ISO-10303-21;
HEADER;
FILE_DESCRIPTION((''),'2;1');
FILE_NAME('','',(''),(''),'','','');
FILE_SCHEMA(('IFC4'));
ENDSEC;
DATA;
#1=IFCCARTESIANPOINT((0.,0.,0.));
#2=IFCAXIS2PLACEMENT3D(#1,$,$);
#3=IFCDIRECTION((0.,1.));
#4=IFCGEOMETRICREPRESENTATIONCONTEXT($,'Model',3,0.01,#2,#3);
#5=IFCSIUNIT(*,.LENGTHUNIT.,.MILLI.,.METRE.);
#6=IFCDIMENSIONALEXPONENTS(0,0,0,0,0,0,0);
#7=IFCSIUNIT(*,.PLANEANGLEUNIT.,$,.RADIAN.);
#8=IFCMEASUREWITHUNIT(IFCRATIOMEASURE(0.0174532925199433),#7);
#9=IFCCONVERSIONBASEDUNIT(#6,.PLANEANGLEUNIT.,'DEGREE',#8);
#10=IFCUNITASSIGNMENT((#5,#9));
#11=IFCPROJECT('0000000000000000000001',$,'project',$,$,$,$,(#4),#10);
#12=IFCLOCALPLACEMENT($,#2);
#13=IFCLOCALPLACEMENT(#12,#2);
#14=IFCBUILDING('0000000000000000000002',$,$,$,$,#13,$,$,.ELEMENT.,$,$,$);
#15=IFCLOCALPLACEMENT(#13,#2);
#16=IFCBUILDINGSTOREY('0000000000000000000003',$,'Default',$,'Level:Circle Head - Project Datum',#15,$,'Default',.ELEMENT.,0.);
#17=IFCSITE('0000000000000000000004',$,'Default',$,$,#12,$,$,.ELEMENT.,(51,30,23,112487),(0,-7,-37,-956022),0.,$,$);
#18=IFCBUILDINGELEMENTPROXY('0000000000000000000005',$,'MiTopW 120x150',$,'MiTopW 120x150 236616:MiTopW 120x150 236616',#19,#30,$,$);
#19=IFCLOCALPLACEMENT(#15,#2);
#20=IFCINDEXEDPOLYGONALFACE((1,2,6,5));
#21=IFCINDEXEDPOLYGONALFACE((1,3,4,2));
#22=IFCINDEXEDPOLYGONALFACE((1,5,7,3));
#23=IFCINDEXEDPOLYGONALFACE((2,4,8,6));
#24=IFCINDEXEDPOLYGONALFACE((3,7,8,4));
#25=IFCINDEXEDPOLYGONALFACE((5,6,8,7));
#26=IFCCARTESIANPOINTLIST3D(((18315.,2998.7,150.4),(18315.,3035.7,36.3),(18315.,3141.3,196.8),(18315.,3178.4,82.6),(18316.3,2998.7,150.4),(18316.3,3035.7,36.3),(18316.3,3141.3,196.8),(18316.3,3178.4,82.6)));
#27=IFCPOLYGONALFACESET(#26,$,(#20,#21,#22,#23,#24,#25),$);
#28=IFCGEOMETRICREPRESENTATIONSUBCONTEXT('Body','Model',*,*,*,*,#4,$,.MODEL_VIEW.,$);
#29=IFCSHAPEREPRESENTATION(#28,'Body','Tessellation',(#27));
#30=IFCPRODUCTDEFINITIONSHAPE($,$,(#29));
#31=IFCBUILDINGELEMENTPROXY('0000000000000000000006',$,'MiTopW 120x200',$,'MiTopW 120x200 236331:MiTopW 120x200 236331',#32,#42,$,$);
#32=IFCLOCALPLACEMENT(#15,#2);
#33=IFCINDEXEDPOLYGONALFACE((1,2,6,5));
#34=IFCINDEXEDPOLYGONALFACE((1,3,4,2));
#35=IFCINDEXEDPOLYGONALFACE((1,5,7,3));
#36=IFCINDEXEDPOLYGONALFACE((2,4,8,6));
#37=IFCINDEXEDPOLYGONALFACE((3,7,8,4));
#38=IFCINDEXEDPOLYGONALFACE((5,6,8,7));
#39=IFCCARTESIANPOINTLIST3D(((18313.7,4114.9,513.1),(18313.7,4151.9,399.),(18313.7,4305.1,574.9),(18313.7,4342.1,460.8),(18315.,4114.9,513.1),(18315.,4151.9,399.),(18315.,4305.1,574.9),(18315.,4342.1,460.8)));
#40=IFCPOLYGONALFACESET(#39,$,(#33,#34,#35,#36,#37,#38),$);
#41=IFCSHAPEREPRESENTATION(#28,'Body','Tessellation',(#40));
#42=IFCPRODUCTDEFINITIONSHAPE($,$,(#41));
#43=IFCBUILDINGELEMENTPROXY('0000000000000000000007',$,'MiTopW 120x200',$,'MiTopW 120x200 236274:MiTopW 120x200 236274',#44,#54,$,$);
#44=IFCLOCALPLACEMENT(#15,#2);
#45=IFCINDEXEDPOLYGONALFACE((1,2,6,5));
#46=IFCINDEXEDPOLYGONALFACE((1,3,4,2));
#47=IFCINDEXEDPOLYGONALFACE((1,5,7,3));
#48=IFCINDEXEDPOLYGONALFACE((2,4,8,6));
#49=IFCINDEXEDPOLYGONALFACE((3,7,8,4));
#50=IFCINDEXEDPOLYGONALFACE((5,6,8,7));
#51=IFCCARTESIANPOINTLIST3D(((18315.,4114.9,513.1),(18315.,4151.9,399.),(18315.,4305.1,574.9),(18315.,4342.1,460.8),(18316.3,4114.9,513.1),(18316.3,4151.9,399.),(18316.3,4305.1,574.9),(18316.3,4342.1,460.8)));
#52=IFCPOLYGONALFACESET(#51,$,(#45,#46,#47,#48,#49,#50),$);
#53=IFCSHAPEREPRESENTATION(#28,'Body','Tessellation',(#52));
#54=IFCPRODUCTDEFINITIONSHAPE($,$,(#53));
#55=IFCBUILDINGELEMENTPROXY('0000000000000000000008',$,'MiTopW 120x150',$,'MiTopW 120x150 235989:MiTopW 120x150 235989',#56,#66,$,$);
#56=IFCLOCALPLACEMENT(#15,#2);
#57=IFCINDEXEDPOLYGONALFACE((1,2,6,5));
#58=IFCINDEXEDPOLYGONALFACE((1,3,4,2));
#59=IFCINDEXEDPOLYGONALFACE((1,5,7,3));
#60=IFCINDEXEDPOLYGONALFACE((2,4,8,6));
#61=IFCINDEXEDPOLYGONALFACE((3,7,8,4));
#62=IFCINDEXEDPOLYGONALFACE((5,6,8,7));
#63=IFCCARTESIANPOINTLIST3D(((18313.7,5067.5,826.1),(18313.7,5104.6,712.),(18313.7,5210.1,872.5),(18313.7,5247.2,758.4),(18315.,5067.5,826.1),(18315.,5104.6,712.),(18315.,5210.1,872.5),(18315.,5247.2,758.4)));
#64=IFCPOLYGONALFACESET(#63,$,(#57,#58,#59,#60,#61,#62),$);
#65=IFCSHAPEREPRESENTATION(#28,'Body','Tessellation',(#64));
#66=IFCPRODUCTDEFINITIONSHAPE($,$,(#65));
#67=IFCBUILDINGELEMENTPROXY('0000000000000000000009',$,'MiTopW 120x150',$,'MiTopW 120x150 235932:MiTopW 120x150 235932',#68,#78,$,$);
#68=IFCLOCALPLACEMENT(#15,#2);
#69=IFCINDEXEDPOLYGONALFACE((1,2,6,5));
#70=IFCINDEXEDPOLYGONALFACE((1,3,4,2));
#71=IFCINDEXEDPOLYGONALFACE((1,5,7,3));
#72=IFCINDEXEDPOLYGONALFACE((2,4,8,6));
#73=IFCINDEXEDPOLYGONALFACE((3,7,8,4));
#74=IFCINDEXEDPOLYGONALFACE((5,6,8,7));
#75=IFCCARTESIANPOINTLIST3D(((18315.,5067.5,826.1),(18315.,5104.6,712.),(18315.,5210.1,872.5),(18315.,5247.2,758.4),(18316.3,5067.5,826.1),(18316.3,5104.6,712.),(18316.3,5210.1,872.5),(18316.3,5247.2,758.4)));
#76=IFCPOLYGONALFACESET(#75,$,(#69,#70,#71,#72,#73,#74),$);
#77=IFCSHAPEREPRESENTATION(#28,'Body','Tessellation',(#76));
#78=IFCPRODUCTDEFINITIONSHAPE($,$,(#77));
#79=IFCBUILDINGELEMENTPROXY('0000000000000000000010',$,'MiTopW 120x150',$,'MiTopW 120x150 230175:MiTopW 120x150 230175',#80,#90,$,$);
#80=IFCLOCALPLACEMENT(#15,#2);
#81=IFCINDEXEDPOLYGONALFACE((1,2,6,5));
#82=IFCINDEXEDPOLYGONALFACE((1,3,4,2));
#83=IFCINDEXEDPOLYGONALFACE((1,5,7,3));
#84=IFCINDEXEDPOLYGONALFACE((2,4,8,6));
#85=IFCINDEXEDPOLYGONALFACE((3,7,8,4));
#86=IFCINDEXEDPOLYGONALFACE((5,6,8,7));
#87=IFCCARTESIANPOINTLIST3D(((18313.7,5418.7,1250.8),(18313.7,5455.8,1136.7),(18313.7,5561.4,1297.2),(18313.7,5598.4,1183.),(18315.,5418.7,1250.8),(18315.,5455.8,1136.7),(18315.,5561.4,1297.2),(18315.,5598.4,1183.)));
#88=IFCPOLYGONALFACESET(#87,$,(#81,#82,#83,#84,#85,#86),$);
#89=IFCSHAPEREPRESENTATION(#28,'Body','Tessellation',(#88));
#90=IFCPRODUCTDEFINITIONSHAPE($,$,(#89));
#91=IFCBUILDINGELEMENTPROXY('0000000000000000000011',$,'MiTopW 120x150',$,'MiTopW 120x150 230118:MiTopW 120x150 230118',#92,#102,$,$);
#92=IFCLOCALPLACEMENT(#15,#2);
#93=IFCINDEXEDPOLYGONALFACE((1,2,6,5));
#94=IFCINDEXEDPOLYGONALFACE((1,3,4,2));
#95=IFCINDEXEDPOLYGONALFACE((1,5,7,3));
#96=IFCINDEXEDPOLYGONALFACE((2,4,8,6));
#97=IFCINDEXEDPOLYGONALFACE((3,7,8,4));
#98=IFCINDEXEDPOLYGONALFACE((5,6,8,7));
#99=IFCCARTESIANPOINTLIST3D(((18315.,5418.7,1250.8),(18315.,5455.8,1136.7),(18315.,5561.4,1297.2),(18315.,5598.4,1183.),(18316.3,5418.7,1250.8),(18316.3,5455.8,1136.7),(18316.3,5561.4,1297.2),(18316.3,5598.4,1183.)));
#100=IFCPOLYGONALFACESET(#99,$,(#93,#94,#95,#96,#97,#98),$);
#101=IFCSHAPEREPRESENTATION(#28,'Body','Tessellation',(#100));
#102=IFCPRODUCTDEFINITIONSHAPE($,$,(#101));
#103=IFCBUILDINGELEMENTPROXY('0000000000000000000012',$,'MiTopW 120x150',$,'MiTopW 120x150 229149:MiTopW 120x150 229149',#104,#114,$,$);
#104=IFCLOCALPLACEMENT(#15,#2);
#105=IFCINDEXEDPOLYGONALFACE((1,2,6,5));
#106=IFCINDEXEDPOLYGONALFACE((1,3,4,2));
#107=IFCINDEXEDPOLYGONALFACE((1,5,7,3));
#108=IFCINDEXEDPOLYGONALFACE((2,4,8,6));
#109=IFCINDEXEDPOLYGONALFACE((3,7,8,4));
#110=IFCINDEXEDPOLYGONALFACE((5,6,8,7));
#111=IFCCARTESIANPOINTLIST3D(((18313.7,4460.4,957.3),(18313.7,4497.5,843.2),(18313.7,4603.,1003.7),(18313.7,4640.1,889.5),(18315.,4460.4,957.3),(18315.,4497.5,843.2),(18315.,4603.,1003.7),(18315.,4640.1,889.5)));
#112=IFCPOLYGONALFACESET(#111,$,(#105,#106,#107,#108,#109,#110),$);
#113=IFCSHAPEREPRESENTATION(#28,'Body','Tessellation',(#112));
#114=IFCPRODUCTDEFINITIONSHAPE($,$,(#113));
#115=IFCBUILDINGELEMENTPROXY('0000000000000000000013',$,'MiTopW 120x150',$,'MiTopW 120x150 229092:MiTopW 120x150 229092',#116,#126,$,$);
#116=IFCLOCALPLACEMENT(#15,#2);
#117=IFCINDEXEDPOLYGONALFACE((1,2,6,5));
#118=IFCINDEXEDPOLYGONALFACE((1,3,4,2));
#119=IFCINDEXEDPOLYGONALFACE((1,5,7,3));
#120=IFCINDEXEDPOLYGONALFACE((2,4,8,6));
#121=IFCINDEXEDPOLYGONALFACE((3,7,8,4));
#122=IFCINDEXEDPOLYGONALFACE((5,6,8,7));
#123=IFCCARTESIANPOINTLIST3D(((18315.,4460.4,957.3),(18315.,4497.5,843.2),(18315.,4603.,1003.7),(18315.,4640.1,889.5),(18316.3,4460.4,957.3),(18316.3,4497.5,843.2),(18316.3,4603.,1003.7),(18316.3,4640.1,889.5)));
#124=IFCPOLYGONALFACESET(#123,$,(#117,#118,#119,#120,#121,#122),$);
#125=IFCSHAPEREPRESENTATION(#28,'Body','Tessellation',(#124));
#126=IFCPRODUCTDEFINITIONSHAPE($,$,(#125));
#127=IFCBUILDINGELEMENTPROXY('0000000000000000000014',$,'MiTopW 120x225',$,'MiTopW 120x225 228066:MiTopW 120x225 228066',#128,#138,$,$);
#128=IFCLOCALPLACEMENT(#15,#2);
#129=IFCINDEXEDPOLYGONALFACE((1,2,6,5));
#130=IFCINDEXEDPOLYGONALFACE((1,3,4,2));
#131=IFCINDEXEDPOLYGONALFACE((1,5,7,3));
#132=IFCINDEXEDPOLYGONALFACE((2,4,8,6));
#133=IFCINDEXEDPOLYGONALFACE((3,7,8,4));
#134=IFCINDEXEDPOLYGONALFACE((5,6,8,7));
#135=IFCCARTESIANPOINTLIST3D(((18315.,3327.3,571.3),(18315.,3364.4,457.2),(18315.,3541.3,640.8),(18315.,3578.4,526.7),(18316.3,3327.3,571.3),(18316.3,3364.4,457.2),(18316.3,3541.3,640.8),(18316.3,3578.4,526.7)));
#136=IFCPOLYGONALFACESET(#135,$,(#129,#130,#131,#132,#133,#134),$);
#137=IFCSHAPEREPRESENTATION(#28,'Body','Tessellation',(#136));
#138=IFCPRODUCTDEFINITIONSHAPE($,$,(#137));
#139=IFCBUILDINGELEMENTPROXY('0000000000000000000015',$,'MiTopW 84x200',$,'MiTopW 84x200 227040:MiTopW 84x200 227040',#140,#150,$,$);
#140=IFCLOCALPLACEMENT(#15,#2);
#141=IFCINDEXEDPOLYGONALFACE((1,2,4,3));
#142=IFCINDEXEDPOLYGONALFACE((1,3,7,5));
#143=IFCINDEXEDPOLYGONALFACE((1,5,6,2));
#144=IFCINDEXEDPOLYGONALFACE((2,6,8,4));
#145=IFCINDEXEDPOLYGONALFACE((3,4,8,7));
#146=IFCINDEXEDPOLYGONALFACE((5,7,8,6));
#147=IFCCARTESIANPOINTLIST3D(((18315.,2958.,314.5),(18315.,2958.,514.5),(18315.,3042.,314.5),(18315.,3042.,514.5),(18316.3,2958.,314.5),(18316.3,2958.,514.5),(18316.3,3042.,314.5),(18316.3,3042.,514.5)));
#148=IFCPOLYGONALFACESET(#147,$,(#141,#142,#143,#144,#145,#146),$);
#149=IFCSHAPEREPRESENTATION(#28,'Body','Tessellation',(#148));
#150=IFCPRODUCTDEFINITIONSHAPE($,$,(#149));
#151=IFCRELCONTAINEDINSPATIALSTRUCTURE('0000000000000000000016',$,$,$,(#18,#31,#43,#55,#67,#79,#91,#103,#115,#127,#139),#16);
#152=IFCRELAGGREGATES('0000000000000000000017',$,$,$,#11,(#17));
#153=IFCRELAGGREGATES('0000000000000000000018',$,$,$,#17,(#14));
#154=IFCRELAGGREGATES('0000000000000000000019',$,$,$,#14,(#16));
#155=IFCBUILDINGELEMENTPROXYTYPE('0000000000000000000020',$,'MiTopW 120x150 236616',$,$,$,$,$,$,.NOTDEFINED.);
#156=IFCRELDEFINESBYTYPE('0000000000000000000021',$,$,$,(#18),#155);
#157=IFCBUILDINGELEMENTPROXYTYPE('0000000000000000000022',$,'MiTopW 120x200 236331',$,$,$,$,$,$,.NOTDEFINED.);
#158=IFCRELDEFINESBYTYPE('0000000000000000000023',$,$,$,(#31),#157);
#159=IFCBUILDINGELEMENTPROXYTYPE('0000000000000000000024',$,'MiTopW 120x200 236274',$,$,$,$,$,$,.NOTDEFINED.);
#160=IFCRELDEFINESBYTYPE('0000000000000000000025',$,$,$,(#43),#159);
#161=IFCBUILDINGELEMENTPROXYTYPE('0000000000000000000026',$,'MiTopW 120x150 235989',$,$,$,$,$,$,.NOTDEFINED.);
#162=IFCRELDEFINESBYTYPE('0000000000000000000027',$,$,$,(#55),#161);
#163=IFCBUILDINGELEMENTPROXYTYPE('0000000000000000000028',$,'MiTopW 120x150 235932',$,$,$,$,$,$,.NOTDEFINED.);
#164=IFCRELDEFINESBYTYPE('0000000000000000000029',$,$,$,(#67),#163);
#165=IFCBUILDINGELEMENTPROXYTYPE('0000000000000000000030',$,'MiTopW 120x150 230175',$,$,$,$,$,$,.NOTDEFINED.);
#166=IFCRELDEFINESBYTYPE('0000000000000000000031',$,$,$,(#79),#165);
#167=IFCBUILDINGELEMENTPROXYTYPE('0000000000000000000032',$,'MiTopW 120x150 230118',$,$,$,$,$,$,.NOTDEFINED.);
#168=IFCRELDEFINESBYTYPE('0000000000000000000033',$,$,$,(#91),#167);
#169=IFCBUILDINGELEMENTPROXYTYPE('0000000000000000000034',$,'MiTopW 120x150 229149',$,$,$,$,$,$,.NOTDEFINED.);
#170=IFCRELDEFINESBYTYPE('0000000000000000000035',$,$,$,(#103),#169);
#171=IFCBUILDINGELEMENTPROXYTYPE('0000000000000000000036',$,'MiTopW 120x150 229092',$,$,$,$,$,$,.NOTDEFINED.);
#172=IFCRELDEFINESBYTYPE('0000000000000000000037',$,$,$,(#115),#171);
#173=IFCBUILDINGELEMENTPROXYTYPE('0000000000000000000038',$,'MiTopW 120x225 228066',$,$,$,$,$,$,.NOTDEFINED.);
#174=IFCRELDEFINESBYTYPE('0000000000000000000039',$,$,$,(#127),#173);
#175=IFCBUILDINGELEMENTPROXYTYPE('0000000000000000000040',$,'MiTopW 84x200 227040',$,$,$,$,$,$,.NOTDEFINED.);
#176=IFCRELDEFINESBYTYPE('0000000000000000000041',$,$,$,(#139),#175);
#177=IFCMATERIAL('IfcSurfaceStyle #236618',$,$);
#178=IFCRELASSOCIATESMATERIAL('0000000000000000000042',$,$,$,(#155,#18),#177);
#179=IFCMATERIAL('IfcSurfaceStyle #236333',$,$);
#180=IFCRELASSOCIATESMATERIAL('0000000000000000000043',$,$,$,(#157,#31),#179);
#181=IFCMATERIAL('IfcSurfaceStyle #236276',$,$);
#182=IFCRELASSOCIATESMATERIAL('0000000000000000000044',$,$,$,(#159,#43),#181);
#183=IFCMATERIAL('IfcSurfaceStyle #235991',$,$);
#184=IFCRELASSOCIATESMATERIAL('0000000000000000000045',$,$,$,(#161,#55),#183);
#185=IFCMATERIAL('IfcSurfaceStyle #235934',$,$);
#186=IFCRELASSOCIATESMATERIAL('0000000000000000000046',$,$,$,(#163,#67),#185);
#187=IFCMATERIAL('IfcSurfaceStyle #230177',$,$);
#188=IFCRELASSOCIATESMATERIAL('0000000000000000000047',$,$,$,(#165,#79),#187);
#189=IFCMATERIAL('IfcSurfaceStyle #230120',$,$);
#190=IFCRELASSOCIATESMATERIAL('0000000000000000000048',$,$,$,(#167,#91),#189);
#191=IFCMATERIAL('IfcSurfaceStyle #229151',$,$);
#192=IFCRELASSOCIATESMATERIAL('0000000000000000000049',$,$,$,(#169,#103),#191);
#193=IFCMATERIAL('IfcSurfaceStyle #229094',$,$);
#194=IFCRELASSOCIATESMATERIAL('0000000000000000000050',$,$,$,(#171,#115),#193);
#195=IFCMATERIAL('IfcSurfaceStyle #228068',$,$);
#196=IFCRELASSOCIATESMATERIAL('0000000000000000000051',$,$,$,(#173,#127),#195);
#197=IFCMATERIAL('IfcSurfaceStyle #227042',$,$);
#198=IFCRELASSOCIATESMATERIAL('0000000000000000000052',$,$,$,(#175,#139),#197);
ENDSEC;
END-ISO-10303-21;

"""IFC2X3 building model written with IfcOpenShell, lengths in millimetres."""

from ifc_helpers import new_model, entity, si_unit, converted_unit, direction, frame, frame_2d, origin, place, context, subcontext, project, spatial, polyline, rectangle, outline, extrude, source, transform, mapped, material, type_object, type_shapes, element, save


model = new_model("IFC2X3")

# Units and contexts
model_context = context("Model", 3, precision=0.01, world=origin(), true_north=direction((0.0, 1.0)))
body_context = subcontext(model_context, "Body", "Model", "MODEL_VIEW")
ifc_project = project(units=[si_unit("LENGTHUNIT", "METRE", prefix="MILLI"), converted_unit("PLANEANGLEUNIT", "DEGREE", entity("IfcRatioMeasure", 0.0174532925199433), si_unit("PLANEANGLEUNIT", "RADIAN"), dimensions=[0, 0, 0, 0, 0, 0, 0])], contexts=[model_context])

# Site, building, storey
site_placement = place(None, origin())
site = spatial("IfcSite", under=ifc_project, at=site_placement, Name="Default", CompositionType="ELEMENT", RefLatitude=(51, 30, 23, 112487), RefLongitude=(0, -7, -37, -956022), RefElevation=0.0)
building_placement = place(site_placement, origin())
building = spatial("IfcBuilding", under=site, at=building_placement, CompositionType="ELEMENT")
storey_placement = place(building_placement, origin())
storey = spatial("IfcBuildingStorey", under=building, at=storey_placement, Name="Default", ObjectType="Level:Circle Head - Project Datum", LongName="Default", CompositionType="ELEMENT", Elevation=0.0)

# Building element proxies
ifc_material_1 = material(Name="IfcSurfaceStyle #236618")
building_element_proxy_type_1 = type_object("IfcBuildingElementProxyType", Name="MiTopW 120x150 236616", PredefinedType="NOTDEFINED", material=ifc_material_1)
shared_shape_1 = source(origin(), body_context, "Body", "SweptSolid", [
    extrude(outline(polyline([(-75.0, -60.0), (75.0, -60.0), (75.0, 60.0), (-75.0, 60.0), (-75.0, -60.0)])), frame((75.0, 60.0, 0.0), z_axis=(0.0, 0.0, 1.0), x_axis=(-1.0, 0.0, 0.0)), (0.0, 0.0, 1.0), 1.3),
])
type_shapes(building_element_proxy_type_1, [shared_shape_1])
proxy_1_placement = place(building_placement, frame((18316.3, 2998.7, 150.4), z_axis=(-1.0, 0.0, 0.0), x_axis=(0.0, 0.951057, 0.309017)))
element("IfcBuildingElementProxy", 1, at=proxy_1_placement, inside=storey, type_object=building_element_proxy_type_1, material=ifc_material_1, Name="MiTopW 120x150", ObjectType="MiTopW 120x150 236616:MiTopW 120x150 236616", context=body_context, shape_type="MappedRepresentation", body=[
    mapped(shared_shape_1, transform((0.0, 0.0, 0.0), scale=1.0)),
])
ifc_material_2 = material(Name="IfcSurfaceStyle #236333")
building_element_proxy_type_2 = type_object("IfcBuildingElementProxyType", Name="MiTopW 120x200 236331", PredefinedType="NOTDEFINED", material=ifc_material_2)
shared_shape_2 = source(origin(), body_context, "Body", "SweptSolid", [
    extrude(outline(polyline([(-100.0, -60.0), (100.0, -60.0), (100.0, 60.0), (-100.0, 60.0), (-100.0, -60.0)])), frame((100.0, 60.0, 0.0), z_axis=(0.0, 0.0, 1.0), x_axis=(-1.0, 0.0, 0.0)), (0.0, 0.0, 1.0), 1.3),
])
type_shapes(building_element_proxy_type_2, [shared_shape_2])
proxy_2_placement = place(building_placement, frame((18315.0, 4114.9, 513.1), z_axis=(-1.0, 0.0, 0.0), x_axis=(0.0, 0.951057, 0.309017)))
element("IfcBuildingElementProxy", 2, at=proxy_2_placement, inside=storey, type_object=building_element_proxy_type_2, material=ifc_material_2, Name="MiTopW 120x200", ObjectType="MiTopW 120x200 236331:MiTopW 120x200 236331", context=body_context, shape_type="MappedRepresentation", body=[
    mapped(shared_shape_2, transform((0.0, 0.0, 0.0), scale=1.0)),
])
ifc_material_3 = material(Name="IfcSurfaceStyle #236276")
building_element_proxy_type_3 = type_object("IfcBuildingElementProxyType", Name="MiTopW 120x200 236274", PredefinedType="NOTDEFINED", material=ifc_material_3)
shared_shape_3 = source(origin(), body_context, "Body", "SweptSolid", [
    extrude(outline(polyline([(-100.0, -60.0), (100.0, -60.0), (100.0, 60.0), (-100.0, 60.0), (-100.0, -60.0)])), frame((100.0, 60.0, 0.0), z_axis=(0.0, 0.0, 1.0), x_axis=(-1.0, 0.0, 0.0)), (0.0, 0.0, 1.0), 1.3),
])
type_shapes(building_element_proxy_type_3, [shared_shape_3])
proxy_3_placement = place(building_placement, frame((18316.3, 4114.9, 513.1), z_axis=(-1.0, 0.0, 0.0), x_axis=(0.0, 0.951057, 0.309017)))
element("IfcBuildingElementProxy", 3, at=proxy_3_placement, inside=storey, type_object=building_element_proxy_type_3, material=ifc_material_3, Name="MiTopW 120x200", ObjectType="MiTopW 120x200 236274:MiTopW 120x200 236274", context=body_context, shape_type="MappedRepresentation", body=[
    mapped(shared_shape_3, transform((0.0, 0.0, 0.0), scale=1.0)),
])
ifc_material_4 = material(Name="IfcSurfaceStyle #235991")
building_element_proxy_type_4 = type_object("IfcBuildingElementProxyType", Name="MiTopW 120x150 235989", PredefinedType="NOTDEFINED", material=ifc_material_4)
shared_shape_4 = source(origin(), body_context, "Body", "SweptSolid", [
    extrude(outline(polyline([(-75.0, -60.0), (75.0, -60.0), (75.0, 60.0), (-75.0, 60.0), (-75.0, -60.0)])), frame((75.0, 60.0, 0.0), z_axis=(0.0, 0.0, 1.0), x_axis=(-1.0, 0.0, 0.0)), (0.0, 0.0, 1.0), 1.3),
])
type_shapes(building_element_proxy_type_4, [shared_shape_4])
proxy_4_placement = place(building_placement, frame((18315.0, 5067.5, 826.1), z_axis=(-1.0, 0.0, 0.0), x_axis=(0.0, 0.951057, 0.309017)))
element("IfcBuildingElementProxy", 4, at=proxy_4_placement, inside=storey, type_object=building_element_proxy_type_4, material=ifc_material_4, Name="MiTopW 120x150", ObjectType="MiTopW 120x150 235989:MiTopW 120x150 235989", context=body_context, shape_type="MappedRepresentation", body=[
    mapped(shared_shape_4, transform((0.0, 0.0, 0.0), scale=1.0)),
])
ifc_material_5 = material(Name="IfcSurfaceStyle #235934")
building_element_proxy_type_5 = type_object("IfcBuildingElementProxyType", Name="MiTopW 120x150 235932", PredefinedType="NOTDEFINED", material=ifc_material_5)
shared_shape_5 = source(origin(), body_context, "Body", "SweptSolid", [
    extrude(outline(polyline([(-75.0, -60.0), (75.0, -60.0), (75.0, 60.0), (-75.0, 60.0), (-75.0, -60.0)])), frame((75.0, 60.0, 0.0), z_axis=(0.0, 0.0, 1.0), x_axis=(-1.0, 0.0, 0.0)), (0.0, 0.0, 1.0), 1.3),
])
type_shapes(building_element_proxy_type_5, [shared_shape_5])
proxy_5_placement = place(building_placement, frame((18316.3, 5067.5, 826.1), z_axis=(-1.0, 0.0, 0.0), x_axis=(0.0, 0.951057, 0.309017)))
element("IfcBuildingElementProxy", 5, at=proxy_5_placement, inside=storey, type_object=building_element_proxy_type_5, material=ifc_material_5, Name="MiTopW 120x150", ObjectType="MiTopW 120x150 235932:MiTopW 120x150 235932", context=body_context, shape_type="MappedRepresentation", body=[
    mapped(shared_shape_5, transform((0.0, 0.0, 0.0), scale=1.0)),
])
ifc_material_6 = material(Name="IfcSurfaceStyle #230177")
building_element_proxy_type_6 = type_object("IfcBuildingElementProxyType", Name="MiTopW 120x150 230175", PredefinedType="NOTDEFINED", material=ifc_material_6)
shared_shape_6 = source(origin(), body_context, "Body", "SweptSolid", [
    extrude(outline(polyline([(-75.0, -60.0), (75.0, -60.0), (75.0, 60.0), (-75.0, 60.0), (-75.0, -60.0)])), frame((75.0, 60.0, 0.0), z_axis=(0.0, 0.0, 1.0), x_axis=(-1.0, 0.0, 0.0)), (0.0, 0.0, 1.0), 1.3),
])
type_shapes(building_element_proxy_type_6, [shared_shape_6])
proxy_6_placement = place(building_placement, frame((18315.0, 5418.7, 1250.8), z_axis=(-1.0, 0.0, 0.0), x_axis=(0.0, 0.951057, 0.309017)))
element("IfcBuildingElementProxy", 6, at=proxy_6_placement, inside=storey, type_object=building_element_proxy_type_6, material=ifc_material_6, Name="MiTopW 120x150", ObjectType="MiTopW 120x150 230175:MiTopW 120x150 230175", context=body_context, shape_type="MappedRepresentation", body=[
    mapped(shared_shape_6, transform((0.0, 0.0, 0.0), scale=1.0)),
])
ifc_material_7 = material(Name="IfcSurfaceStyle #230120")
building_element_proxy_type_7 = type_object("IfcBuildingElementProxyType", Name="MiTopW 120x150 230118", PredefinedType="NOTDEFINED", material=ifc_material_7)
shared_shape_7 = source(origin(), body_context, "Body", "SweptSolid", [
    extrude(outline(polyline([(-75.0, -60.0), (75.0, -60.0), (75.0, 60.0), (-75.0, 60.0), (-75.0, -60.0)])), frame((75.0, 60.0, 0.0), z_axis=(0.0, 0.0, 1.0), x_axis=(-1.0, 0.0, 0.0)), (0.0, 0.0, 1.0), 1.3),
])
type_shapes(building_element_proxy_type_7, [shared_shape_7])
proxy_7_placement = place(building_placement, frame((18316.3, 5418.7, 1250.8), z_axis=(-1.0, 0.0, 0.0), x_axis=(0.0, 0.951057, 0.309017)))
element("IfcBuildingElementProxy", 7, at=proxy_7_placement, inside=storey, type_object=building_element_proxy_type_7, material=ifc_material_7, Name="MiTopW 120x150", ObjectType="MiTopW 120x150 230118:MiTopW 120x150 230118", context=body_context, shape_type="MappedRepresentation", body=[
    mapped(shared_shape_7, transform((0.0, 0.0, 0.0), scale=1.0)),
])
ifc_material_8 = material(Name="IfcSurfaceStyle #229151")
building_element_proxy_type_8 = type_object("IfcBuildingElementProxyType", Name="MiTopW 120x150 229149", PredefinedType="NOTDEFINED", material=ifc_material_8)
shared_shape_8 = source(origin(), body_context, "Body", "SweptSolid", [
    extrude(outline(polyline([(-75.0, -60.0), (75.0, -60.0), (75.0, 60.0), (-75.0, 60.0), (-75.0, -60.0)])), frame((75.0, 60.0, 0.0), z_axis=(0.0, 0.0, 1.0), x_axis=(-1.0, 0.0, 0.0)), (0.0, 0.0, 1.0), 1.3),
])
type_shapes(building_element_proxy_type_8, [shared_shape_8])
proxy_8_placement = place(building_placement, frame((18315.0, 4460.4, 957.3), z_axis=(-1.0, 0.0, 0.0), x_axis=(0.0, 0.951057, 0.309017)))
element("IfcBuildingElementProxy", 8, at=proxy_8_placement, inside=storey, type_object=building_element_proxy_type_8, material=ifc_material_8, Name="MiTopW 120x150", ObjectType="MiTopW 120x150 229149:MiTopW 120x150 229149", context=body_context, shape_type="MappedRepresentation", body=[
    mapped(shared_shape_8, transform((0.0, 0.0, 0.0), scale=1.0)),
])
ifc_material_9 = material(Name="IfcSurfaceStyle #229094")
building_element_proxy_type_9 = type_object("IfcBuildingElementProxyType", Name="MiTopW 120x150 229092", PredefinedType="NOTDEFINED", material=ifc_material_9)
shared_shape_9 = source(origin(), body_context, "Body", "SweptSolid", [
    extrude(outline(polyline([(-75.0, -60.0), (75.0, -60.0), (75.0, 60.0), (-75.0, 60.0), (-75.0, -60.0)])), frame((75.0, 60.0, 0.0), z_axis=(0.0, 0.0, 1.0), x_axis=(-1.0, 0.0, 0.0)), (0.0, 0.0, 1.0), 1.3),
])
type_shapes(building_element_proxy_type_9, [shared_shape_9])
proxy_9_placement = place(building_placement, frame((18316.3, 4460.4, 957.3), z_axis=(-1.0, 0.0, 0.0), x_axis=(0.0, 0.951057, 0.309017)))
element("IfcBuildingElementProxy", 9, at=proxy_9_placement, inside=storey, type_object=building_element_proxy_type_9, material=ifc_material_9, Name="MiTopW 120x150", ObjectType="MiTopW 120x150 229092:MiTopW 120x150 229092", context=body_context, shape_type="MappedRepresentation", body=[
    mapped(shared_shape_9, transform((0.0, 0.0, 0.0), scale=1.0)),
])
ifc_material_10 = material(Name="IfcSurfaceStyle #228068")
building_element_proxy_type_10 = type_object("IfcBuildingElementProxyType", Name="MiTopW 120x225 228066", PredefinedType="NOTDEFINED", material=ifc_material_10)
shared_shape_10 = source(origin(), body_context, "Body", "SweptSolid", [
    extrude(outline(polyline([(-112.5, -60.0), (112.5, -60.0), (112.5, 60.0), (-112.5, 60.0), (-112.5, -60.0)])), frame((112.5, 60.0, 0.0), z_axis=(0.0, 0.0, 1.0), x_axis=(-1.0, 0.0, 0.0)), (0.0, 0.0, 1.0), 1.3),
])
type_shapes(building_element_proxy_type_10, [shared_shape_10])
proxy_10_placement = place(building_placement, frame((18316.3, 3327.3, 571.3), z_axis=(-1.0, 0.0, 0.0), x_axis=(0.0, 0.951057, 0.309017)))
element("IfcBuildingElementProxy", 10, at=proxy_10_placement, inside=storey, type_object=building_element_proxy_type_10, material=ifc_material_10, Name="MiTopW 120x225", ObjectType="MiTopW 120x225 228066:MiTopW 120x225 228066", context=body_context, shape_type="MappedRepresentation", body=[
    mapped(shared_shape_10, transform((0.0, 0.0, 0.0), scale=1.0)),
])
ifc_material_11 = material(Name="IfcSurfaceStyle #227042")
building_element_proxy_type_11 = type_object("IfcBuildingElementProxyType", Name="MiTopW 84x200 227040", PredefinedType="NOTDEFINED", material=ifc_material_11)
shared_shape_11 = source(origin(), body_context, "Body", "SweptSolid", [
    extrude(rectangle(XDim=200.0, YDim=84.0, at=frame_2d((0.0, 0.0), x_axis=(1.0, 0.0))), frame((100.0, 42.0, 0.0), z_axis=(0.0, 0.0, 1.0), x_axis=(-1.0, 0.0, 0.0)), (0.0, 0.0, 1.0), 1.3),
])
type_shapes(building_element_proxy_type_11, [shared_shape_11])
proxy_11_placement = place(building_placement, frame((18316.3, 3042.0, 514.5), z_axis=(-1.0, 0.0, 0.0), x_axis=(0.0, 0.0, -1.0)))
element("IfcBuildingElementProxy", 11, at=proxy_11_placement, inside=storey, type_object=building_element_proxy_type_11, material=ifc_material_11, Name="MiTopW 84x200", ObjectType="MiTopW 84x200 227040:MiTopW 84x200 227040", context=body_context, shape_type="MappedRepresentation", body=[
    mapped(shared_shape_11, transform((0.0, 0.0, 0.0), scale=1.0)),
])

save(model, "model.ifc")
